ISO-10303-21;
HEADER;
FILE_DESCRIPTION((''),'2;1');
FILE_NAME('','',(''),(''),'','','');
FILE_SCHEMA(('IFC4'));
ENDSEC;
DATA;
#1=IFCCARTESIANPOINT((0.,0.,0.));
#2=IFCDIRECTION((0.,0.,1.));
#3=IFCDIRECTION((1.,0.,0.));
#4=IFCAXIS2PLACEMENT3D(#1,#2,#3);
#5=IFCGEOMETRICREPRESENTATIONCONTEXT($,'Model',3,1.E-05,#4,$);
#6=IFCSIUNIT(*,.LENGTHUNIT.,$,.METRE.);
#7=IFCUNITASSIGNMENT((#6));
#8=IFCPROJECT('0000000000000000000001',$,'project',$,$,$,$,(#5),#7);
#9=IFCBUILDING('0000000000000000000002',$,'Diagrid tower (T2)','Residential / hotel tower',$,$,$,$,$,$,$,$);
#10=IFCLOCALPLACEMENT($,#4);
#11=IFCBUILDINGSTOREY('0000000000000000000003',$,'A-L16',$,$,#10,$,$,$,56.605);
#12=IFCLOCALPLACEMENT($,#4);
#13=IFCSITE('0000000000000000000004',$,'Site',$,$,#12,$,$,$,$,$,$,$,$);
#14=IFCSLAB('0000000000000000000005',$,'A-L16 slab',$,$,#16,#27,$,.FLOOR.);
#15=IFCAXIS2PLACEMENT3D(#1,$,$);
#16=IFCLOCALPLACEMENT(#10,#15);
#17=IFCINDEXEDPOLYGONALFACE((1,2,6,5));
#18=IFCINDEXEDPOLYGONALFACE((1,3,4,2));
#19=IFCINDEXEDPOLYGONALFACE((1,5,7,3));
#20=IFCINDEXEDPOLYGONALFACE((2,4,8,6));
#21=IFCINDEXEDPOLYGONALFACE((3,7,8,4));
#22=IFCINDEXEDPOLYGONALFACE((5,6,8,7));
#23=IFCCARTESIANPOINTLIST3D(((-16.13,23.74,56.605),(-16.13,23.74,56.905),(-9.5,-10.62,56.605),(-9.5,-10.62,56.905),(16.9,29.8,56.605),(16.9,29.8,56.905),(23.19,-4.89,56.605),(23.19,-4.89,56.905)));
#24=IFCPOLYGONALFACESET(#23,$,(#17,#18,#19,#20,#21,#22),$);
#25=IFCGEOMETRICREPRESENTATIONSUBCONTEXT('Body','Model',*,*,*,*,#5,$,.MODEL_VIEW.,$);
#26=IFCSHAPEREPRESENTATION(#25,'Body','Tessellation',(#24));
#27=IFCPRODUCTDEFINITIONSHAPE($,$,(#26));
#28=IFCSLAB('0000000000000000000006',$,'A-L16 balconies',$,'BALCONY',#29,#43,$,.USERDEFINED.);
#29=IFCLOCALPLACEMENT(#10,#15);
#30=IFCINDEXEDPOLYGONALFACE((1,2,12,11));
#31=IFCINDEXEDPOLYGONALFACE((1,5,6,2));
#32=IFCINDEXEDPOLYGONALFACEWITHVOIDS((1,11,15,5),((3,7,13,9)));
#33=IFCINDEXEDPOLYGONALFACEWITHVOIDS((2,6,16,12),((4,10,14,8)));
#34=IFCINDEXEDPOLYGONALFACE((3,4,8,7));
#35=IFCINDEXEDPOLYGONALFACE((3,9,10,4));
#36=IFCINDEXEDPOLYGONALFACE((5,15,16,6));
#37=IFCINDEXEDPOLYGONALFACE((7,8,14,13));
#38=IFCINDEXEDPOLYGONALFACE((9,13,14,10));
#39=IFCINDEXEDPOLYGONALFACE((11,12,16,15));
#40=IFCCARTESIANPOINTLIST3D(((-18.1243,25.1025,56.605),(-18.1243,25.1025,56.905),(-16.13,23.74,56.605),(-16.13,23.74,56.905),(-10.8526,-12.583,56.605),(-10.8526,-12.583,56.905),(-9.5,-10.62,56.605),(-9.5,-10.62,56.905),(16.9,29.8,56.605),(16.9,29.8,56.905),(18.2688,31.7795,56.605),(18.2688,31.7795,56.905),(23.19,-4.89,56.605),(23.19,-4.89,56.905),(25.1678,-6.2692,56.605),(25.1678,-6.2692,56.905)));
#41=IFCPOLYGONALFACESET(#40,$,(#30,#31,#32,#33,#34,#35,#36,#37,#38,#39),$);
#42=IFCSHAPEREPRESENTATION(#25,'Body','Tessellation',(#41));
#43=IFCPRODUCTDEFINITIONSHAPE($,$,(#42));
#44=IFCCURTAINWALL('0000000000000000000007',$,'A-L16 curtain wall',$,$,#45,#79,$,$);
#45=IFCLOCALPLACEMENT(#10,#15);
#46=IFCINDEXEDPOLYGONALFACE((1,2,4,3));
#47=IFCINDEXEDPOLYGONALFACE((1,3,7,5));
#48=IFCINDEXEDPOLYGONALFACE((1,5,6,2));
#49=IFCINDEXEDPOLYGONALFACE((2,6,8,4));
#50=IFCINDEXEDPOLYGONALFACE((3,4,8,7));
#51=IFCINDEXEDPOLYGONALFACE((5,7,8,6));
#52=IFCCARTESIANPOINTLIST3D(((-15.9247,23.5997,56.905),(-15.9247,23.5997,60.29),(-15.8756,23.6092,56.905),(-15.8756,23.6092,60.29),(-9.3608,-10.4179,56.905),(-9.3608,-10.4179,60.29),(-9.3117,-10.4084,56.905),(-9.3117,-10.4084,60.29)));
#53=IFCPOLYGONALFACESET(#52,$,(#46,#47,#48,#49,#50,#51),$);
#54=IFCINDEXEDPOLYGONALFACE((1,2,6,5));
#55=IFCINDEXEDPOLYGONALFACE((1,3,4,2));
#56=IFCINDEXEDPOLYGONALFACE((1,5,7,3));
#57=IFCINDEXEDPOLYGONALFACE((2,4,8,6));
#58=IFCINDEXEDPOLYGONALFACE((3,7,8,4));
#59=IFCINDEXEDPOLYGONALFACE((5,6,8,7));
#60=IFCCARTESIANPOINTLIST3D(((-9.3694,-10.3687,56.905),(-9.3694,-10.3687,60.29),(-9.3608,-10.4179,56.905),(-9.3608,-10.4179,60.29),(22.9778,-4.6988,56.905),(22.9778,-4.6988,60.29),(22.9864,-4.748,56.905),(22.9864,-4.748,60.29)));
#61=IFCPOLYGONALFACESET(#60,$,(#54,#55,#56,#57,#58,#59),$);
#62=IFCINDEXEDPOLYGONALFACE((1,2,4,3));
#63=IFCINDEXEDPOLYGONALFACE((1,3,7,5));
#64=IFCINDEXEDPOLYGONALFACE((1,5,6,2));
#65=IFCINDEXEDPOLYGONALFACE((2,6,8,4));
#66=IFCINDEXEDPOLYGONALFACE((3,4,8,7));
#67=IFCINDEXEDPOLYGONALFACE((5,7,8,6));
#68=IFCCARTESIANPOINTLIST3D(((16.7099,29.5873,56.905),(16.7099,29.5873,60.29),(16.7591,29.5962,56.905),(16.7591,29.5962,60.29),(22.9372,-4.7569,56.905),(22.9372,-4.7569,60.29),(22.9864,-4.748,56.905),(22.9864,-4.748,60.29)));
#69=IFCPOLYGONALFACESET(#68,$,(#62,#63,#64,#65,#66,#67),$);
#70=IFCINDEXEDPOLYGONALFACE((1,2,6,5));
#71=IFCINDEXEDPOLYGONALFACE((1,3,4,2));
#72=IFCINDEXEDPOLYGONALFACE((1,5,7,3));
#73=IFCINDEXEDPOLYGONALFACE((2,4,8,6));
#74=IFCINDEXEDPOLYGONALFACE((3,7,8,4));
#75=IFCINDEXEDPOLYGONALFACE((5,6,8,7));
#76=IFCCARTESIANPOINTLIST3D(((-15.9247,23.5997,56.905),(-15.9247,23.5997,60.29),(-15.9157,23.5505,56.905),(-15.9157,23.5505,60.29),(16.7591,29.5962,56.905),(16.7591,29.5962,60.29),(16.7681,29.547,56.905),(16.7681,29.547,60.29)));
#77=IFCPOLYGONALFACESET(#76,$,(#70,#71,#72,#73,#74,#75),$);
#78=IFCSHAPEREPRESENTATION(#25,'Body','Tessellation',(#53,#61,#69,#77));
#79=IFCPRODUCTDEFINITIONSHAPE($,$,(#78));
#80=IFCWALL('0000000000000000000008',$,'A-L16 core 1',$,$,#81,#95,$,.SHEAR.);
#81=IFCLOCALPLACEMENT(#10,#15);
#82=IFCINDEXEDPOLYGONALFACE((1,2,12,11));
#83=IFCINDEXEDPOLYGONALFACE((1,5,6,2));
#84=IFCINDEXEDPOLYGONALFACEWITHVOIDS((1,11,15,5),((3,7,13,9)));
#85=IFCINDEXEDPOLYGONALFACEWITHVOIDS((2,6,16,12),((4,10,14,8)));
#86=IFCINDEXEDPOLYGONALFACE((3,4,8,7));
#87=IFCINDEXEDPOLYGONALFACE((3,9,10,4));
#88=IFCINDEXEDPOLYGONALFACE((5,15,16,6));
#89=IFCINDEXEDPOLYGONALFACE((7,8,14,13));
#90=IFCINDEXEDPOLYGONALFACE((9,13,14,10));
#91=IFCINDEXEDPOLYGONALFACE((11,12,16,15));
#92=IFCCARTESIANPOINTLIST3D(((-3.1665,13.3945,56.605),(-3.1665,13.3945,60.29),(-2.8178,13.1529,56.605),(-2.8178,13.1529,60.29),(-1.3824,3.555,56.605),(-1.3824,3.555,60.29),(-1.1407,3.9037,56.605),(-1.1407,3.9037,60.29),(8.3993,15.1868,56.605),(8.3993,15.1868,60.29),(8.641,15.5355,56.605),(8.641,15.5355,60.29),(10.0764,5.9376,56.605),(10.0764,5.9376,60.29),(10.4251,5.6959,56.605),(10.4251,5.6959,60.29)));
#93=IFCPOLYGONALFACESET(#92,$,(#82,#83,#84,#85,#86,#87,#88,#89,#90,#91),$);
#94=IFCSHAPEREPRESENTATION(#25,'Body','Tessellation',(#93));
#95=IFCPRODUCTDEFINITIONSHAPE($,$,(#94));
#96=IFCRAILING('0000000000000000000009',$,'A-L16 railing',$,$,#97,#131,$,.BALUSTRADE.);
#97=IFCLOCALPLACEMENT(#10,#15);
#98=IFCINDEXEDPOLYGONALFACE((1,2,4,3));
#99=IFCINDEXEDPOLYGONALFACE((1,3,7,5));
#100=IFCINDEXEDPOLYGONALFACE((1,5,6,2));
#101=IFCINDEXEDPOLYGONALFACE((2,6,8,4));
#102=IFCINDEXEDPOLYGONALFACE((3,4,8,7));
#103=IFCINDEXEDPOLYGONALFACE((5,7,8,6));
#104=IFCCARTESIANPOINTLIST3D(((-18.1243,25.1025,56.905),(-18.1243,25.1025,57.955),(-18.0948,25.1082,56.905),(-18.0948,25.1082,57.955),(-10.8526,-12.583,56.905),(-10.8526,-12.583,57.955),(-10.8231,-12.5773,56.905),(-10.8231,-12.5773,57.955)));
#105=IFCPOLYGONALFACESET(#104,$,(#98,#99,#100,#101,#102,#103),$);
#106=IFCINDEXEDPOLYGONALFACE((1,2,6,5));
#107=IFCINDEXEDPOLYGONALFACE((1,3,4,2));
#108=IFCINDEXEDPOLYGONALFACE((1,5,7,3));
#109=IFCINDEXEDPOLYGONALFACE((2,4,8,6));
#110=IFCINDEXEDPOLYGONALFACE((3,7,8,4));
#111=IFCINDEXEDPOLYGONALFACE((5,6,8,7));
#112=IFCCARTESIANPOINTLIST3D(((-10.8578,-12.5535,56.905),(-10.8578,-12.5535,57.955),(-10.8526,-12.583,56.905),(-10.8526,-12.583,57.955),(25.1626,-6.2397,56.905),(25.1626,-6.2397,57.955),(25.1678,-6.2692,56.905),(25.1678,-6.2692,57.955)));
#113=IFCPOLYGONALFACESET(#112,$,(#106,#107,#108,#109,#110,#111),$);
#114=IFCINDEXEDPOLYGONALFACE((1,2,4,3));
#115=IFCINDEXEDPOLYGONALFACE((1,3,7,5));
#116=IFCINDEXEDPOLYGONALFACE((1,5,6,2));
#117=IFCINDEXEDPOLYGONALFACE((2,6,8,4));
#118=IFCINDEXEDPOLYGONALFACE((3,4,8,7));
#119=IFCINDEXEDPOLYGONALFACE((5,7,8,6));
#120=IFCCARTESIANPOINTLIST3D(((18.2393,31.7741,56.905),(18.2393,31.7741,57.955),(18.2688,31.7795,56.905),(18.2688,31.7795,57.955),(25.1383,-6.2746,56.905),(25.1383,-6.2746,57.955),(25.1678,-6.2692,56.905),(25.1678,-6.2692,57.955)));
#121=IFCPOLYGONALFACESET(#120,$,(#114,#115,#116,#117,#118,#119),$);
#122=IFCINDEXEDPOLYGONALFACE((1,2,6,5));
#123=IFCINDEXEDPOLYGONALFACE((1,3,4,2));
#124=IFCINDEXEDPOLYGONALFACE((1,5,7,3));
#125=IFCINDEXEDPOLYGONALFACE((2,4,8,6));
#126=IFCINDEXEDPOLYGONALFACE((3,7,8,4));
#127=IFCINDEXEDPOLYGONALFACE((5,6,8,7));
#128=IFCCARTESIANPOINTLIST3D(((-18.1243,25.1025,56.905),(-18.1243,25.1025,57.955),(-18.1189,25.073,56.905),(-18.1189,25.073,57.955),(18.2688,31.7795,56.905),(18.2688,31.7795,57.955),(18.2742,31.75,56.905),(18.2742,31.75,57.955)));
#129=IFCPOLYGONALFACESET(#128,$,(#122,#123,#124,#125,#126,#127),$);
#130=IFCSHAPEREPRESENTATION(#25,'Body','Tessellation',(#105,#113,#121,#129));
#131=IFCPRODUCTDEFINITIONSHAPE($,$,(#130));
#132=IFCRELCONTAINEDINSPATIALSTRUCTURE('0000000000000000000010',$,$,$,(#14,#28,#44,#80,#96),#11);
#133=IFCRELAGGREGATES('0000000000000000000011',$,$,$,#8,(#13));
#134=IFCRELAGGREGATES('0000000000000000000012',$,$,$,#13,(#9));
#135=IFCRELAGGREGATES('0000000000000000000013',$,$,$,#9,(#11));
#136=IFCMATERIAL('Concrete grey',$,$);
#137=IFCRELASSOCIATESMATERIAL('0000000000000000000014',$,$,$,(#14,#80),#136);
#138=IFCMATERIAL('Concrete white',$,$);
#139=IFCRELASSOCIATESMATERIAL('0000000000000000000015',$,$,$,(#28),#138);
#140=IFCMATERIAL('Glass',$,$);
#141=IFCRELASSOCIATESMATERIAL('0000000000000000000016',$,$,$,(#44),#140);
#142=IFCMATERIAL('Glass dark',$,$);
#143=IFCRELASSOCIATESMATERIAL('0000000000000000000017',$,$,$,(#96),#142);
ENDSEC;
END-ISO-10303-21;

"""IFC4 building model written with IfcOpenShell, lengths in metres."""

from ifc_helpers import new_model, si_unit, frame, origin_with_axes, place, context, subcontext, project, spatial, polyline, outline, extrude, material, element, save


model = new_model("IFC4")

# Units and contexts
model_context = context("Model", 3, precision=1e-05, world=origin_with_axes())
body_context = subcontext(model_context, "Body", "Model", "MODEL_VIEW")
ifc_project = project(units=[si_unit("LENGTHUNIT", "METRE")], contexts=[model_context])

# Site, building, storey
site_placement = place(None, origin_with_axes())
site = spatial("IfcSite", under=ifc_project, at=site_placement, Name="Site")
building = spatial("IfcBuilding", under=site, Name="Diagrid tower (T2)", Description="Residential / hotel tower")
storey_placement = place(None, origin_with_axes())
storey = spatial("IfcBuildingStorey", under=building, at=storey_placement, Name="A-L16", Elevation=56.605)

# Slabs
ifc_material_1 = material(Name="Concrete grey")
slab_1_placement = place(storey_placement, origin_with_axes())
element("IfcSlab", 1, at=slab_1_placement, inside=storey, material=ifc_material_1, Name="A-L16 slab", PredefinedType="FLOOR", context=body_context, shape_type="SweptSolid", body=[
    extrude(outline(polyline([(-16.13, 23.74), (-9.5, -10.62), (23.19, -4.89), (16.9, 29.8), (-16.13, 23.74)])), frame((0.0, 0.0, 56.605), z_axis=(0.0, 0.0, 1.0), x_axis=(1.0, 0.0, 0.0)), (0.0, 0.0, 1.0), 0.3),
])
ifc_material_2 = material(Name="Concrete white")
slab_2_placement = place(storey_placement, origin_with_axes())
element("IfcSlab", 2, at=slab_2_placement, inside=storey, material=ifc_material_2, Name="A-L16 balconies", ObjectType="BALCONY", PredefinedType="USERDEFINED", context=body_context, shape_type="SweptSolid", body=[
    extrude(outline(polyline([(-18.1243, 25.1025), (-10.8526, -12.583), (25.1678, -6.2692), (18.2688, 31.7795), (-18.1243, 25.1025)]), holes=[polyline([(-16.13, 23.74), (-9.5, -10.62), (23.19, -4.89), (16.9, 29.8), (-16.13, 23.74)])]), frame((0.0, 0.0, 56.605), z_axis=(0.0, 0.0, 1.0), x_axis=(1.0, 0.0, 0.0)), (0.0, 0.0, 1.0), 0.3),
])

# Curtain wall
ifc_material_3 = material(Name="Glass")
curtain_wall_placement = place(storey_placement, origin_with_axes())
element("IfcCurtainWall", 3, at=curtain_wall_placement, inside=storey, material=ifc_material_3, Name="A-L16 curtain wall", context=body_context, shape_type="SweptSolid", body=[
    extrude(outline(polyline([(-15.9247, 23.5997), (-9.3608, -10.4179), (-9.3117, -10.4084), (-15.8756, 23.6092), (-15.9247, 23.5997)])), frame((0.0, 0.0, 56.905), z_axis=(0.0, 0.0, 1.0), x_axis=(1.0, 0.0, 0.0)), (0.0, 0.0, 1.0), 3.385),
    extrude(outline(polyline([(-9.3608, -10.4179), (22.9864, -4.748), (22.9778, -4.6988), (-9.3694, -10.3687), (-9.3608, -10.4179)])), frame((0.0, 0.0, 56.905), z_axis=(0.0, 0.0, 1.0), x_axis=(1.0, 0.0, 0.0)), (0.0, 0.0, 1.0), 3.385),
    extrude(outline(polyline([(22.9864, -4.748), (16.7591, 29.5962), (16.7099, 29.5873), (22.9372, -4.7569), (22.9864, -4.748)])), frame((0.0, 0.0, 56.905), z_axis=(0.0, 0.0, 1.0), x_axis=(1.0, 0.0, 0.0)), (0.0, 0.0, 1.0), 3.385),
    extrude(outline(polyline([(16.7591, 29.5962), (-15.9247, 23.5997), (-15.9157, 23.5505), (16.7681, 29.547), (16.7591, 29.5962)])), frame((0.0, 0.0, 56.905), z_axis=(0.0, 0.0, 1.0), x_axis=(1.0, 0.0, 0.0)), (0.0, 0.0, 1.0), 3.385),
])

# Wall
wall_placement = place(storey_placement, origin_with_axes())
element("IfcWall", 4, at=wall_placement, inside=storey, material=ifc_material_1, Name="A-L16 core 1", PredefinedType="SHEAR", context=body_context, shape_type="SweptSolid", body=[
    extrude(outline(polyline([(10.4251, 5.6959), (8.641, 15.5355), (-3.1665, 13.3945), (-1.3824, 3.555), (10.4251, 5.6959)]), holes=[polyline([(10.0764, 5.9376), (8.3993, 15.1868), (-2.8178, 13.1529), (-1.1407, 3.9037), (10.0764, 5.9376)])]), frame((0.0, 0.0, 56.605), z_axis=(0.0, 0.0, 1.0), x_axis=(1.0, 0.0, 0.0)), (0.0, 0.0, 1.0), 3.685),
])

# Railing
ifc_material_4 = material(Name="Glass dark")
railing_placement = place(storey_placement, origin_with_axes())
element("IfcRailing", 5, at=railing_placement, inside=storey, material=ifc_material_4, Name="A-L16 railing", PredefinedType="BALUSTRADE", context=body_context, shape_type="SweptSolid", body=[
    extrude(outline(polyline([(-18.1243, 25.1025), (-10.8526, -12.583), (-10.8231, -12.5773), (-18.0948, 25.1082), (-18.1243, 25.1025)])), frame((0.0, 0.0, 56.905), z_axis=(0.0, 0.0, 1.0), x_axis=(1.0, 0.0, 0.0)), (0.0, 0.0, 1.0), 1.05),
    extrude(outline(polyline([(-10.8526, -12.583), (25.1678, -6.2692), (25.1626, -6.2397), (-10.8578, -12.5535), (-10.8526, -12.583)])), frame((0.0, 0.0, 56.905), z_axis=(0.0, 0.0, 1.0), x_axis=(1.0, 0.0, 0.0)), (0.0, 0.0, 1.0), 1.05),
    extrude(outline(polyline([(25.1678, -6.2692), (18.2688, 31.7795), (18.2393, 31.7741), (25.1383, -6.2746), (25.1678, -6.2692)])), frame((0.0, 0.0, 56.905), z_axis=(0.0, 0.0, 1.0), x_axis=(1.0, 0.0, 0.0)), (0.0, 0.0, 1.0), 1.05),
    extrude(outline(polyline([(18.2688, 31.7795), (-18.1243, 25.1025), (-18.1189, 25.073), (18.2742, 31.75), (18.2688, 31.7795)])), frame((0.0, 0.0, 56.905), z_axis=(0.0, 0.0, 1.0), x_axis=(1.0, 0.0, 0.0)), (0.0, 0.0, 1.0), 1.05),
])

save(model, "model.ifc")
